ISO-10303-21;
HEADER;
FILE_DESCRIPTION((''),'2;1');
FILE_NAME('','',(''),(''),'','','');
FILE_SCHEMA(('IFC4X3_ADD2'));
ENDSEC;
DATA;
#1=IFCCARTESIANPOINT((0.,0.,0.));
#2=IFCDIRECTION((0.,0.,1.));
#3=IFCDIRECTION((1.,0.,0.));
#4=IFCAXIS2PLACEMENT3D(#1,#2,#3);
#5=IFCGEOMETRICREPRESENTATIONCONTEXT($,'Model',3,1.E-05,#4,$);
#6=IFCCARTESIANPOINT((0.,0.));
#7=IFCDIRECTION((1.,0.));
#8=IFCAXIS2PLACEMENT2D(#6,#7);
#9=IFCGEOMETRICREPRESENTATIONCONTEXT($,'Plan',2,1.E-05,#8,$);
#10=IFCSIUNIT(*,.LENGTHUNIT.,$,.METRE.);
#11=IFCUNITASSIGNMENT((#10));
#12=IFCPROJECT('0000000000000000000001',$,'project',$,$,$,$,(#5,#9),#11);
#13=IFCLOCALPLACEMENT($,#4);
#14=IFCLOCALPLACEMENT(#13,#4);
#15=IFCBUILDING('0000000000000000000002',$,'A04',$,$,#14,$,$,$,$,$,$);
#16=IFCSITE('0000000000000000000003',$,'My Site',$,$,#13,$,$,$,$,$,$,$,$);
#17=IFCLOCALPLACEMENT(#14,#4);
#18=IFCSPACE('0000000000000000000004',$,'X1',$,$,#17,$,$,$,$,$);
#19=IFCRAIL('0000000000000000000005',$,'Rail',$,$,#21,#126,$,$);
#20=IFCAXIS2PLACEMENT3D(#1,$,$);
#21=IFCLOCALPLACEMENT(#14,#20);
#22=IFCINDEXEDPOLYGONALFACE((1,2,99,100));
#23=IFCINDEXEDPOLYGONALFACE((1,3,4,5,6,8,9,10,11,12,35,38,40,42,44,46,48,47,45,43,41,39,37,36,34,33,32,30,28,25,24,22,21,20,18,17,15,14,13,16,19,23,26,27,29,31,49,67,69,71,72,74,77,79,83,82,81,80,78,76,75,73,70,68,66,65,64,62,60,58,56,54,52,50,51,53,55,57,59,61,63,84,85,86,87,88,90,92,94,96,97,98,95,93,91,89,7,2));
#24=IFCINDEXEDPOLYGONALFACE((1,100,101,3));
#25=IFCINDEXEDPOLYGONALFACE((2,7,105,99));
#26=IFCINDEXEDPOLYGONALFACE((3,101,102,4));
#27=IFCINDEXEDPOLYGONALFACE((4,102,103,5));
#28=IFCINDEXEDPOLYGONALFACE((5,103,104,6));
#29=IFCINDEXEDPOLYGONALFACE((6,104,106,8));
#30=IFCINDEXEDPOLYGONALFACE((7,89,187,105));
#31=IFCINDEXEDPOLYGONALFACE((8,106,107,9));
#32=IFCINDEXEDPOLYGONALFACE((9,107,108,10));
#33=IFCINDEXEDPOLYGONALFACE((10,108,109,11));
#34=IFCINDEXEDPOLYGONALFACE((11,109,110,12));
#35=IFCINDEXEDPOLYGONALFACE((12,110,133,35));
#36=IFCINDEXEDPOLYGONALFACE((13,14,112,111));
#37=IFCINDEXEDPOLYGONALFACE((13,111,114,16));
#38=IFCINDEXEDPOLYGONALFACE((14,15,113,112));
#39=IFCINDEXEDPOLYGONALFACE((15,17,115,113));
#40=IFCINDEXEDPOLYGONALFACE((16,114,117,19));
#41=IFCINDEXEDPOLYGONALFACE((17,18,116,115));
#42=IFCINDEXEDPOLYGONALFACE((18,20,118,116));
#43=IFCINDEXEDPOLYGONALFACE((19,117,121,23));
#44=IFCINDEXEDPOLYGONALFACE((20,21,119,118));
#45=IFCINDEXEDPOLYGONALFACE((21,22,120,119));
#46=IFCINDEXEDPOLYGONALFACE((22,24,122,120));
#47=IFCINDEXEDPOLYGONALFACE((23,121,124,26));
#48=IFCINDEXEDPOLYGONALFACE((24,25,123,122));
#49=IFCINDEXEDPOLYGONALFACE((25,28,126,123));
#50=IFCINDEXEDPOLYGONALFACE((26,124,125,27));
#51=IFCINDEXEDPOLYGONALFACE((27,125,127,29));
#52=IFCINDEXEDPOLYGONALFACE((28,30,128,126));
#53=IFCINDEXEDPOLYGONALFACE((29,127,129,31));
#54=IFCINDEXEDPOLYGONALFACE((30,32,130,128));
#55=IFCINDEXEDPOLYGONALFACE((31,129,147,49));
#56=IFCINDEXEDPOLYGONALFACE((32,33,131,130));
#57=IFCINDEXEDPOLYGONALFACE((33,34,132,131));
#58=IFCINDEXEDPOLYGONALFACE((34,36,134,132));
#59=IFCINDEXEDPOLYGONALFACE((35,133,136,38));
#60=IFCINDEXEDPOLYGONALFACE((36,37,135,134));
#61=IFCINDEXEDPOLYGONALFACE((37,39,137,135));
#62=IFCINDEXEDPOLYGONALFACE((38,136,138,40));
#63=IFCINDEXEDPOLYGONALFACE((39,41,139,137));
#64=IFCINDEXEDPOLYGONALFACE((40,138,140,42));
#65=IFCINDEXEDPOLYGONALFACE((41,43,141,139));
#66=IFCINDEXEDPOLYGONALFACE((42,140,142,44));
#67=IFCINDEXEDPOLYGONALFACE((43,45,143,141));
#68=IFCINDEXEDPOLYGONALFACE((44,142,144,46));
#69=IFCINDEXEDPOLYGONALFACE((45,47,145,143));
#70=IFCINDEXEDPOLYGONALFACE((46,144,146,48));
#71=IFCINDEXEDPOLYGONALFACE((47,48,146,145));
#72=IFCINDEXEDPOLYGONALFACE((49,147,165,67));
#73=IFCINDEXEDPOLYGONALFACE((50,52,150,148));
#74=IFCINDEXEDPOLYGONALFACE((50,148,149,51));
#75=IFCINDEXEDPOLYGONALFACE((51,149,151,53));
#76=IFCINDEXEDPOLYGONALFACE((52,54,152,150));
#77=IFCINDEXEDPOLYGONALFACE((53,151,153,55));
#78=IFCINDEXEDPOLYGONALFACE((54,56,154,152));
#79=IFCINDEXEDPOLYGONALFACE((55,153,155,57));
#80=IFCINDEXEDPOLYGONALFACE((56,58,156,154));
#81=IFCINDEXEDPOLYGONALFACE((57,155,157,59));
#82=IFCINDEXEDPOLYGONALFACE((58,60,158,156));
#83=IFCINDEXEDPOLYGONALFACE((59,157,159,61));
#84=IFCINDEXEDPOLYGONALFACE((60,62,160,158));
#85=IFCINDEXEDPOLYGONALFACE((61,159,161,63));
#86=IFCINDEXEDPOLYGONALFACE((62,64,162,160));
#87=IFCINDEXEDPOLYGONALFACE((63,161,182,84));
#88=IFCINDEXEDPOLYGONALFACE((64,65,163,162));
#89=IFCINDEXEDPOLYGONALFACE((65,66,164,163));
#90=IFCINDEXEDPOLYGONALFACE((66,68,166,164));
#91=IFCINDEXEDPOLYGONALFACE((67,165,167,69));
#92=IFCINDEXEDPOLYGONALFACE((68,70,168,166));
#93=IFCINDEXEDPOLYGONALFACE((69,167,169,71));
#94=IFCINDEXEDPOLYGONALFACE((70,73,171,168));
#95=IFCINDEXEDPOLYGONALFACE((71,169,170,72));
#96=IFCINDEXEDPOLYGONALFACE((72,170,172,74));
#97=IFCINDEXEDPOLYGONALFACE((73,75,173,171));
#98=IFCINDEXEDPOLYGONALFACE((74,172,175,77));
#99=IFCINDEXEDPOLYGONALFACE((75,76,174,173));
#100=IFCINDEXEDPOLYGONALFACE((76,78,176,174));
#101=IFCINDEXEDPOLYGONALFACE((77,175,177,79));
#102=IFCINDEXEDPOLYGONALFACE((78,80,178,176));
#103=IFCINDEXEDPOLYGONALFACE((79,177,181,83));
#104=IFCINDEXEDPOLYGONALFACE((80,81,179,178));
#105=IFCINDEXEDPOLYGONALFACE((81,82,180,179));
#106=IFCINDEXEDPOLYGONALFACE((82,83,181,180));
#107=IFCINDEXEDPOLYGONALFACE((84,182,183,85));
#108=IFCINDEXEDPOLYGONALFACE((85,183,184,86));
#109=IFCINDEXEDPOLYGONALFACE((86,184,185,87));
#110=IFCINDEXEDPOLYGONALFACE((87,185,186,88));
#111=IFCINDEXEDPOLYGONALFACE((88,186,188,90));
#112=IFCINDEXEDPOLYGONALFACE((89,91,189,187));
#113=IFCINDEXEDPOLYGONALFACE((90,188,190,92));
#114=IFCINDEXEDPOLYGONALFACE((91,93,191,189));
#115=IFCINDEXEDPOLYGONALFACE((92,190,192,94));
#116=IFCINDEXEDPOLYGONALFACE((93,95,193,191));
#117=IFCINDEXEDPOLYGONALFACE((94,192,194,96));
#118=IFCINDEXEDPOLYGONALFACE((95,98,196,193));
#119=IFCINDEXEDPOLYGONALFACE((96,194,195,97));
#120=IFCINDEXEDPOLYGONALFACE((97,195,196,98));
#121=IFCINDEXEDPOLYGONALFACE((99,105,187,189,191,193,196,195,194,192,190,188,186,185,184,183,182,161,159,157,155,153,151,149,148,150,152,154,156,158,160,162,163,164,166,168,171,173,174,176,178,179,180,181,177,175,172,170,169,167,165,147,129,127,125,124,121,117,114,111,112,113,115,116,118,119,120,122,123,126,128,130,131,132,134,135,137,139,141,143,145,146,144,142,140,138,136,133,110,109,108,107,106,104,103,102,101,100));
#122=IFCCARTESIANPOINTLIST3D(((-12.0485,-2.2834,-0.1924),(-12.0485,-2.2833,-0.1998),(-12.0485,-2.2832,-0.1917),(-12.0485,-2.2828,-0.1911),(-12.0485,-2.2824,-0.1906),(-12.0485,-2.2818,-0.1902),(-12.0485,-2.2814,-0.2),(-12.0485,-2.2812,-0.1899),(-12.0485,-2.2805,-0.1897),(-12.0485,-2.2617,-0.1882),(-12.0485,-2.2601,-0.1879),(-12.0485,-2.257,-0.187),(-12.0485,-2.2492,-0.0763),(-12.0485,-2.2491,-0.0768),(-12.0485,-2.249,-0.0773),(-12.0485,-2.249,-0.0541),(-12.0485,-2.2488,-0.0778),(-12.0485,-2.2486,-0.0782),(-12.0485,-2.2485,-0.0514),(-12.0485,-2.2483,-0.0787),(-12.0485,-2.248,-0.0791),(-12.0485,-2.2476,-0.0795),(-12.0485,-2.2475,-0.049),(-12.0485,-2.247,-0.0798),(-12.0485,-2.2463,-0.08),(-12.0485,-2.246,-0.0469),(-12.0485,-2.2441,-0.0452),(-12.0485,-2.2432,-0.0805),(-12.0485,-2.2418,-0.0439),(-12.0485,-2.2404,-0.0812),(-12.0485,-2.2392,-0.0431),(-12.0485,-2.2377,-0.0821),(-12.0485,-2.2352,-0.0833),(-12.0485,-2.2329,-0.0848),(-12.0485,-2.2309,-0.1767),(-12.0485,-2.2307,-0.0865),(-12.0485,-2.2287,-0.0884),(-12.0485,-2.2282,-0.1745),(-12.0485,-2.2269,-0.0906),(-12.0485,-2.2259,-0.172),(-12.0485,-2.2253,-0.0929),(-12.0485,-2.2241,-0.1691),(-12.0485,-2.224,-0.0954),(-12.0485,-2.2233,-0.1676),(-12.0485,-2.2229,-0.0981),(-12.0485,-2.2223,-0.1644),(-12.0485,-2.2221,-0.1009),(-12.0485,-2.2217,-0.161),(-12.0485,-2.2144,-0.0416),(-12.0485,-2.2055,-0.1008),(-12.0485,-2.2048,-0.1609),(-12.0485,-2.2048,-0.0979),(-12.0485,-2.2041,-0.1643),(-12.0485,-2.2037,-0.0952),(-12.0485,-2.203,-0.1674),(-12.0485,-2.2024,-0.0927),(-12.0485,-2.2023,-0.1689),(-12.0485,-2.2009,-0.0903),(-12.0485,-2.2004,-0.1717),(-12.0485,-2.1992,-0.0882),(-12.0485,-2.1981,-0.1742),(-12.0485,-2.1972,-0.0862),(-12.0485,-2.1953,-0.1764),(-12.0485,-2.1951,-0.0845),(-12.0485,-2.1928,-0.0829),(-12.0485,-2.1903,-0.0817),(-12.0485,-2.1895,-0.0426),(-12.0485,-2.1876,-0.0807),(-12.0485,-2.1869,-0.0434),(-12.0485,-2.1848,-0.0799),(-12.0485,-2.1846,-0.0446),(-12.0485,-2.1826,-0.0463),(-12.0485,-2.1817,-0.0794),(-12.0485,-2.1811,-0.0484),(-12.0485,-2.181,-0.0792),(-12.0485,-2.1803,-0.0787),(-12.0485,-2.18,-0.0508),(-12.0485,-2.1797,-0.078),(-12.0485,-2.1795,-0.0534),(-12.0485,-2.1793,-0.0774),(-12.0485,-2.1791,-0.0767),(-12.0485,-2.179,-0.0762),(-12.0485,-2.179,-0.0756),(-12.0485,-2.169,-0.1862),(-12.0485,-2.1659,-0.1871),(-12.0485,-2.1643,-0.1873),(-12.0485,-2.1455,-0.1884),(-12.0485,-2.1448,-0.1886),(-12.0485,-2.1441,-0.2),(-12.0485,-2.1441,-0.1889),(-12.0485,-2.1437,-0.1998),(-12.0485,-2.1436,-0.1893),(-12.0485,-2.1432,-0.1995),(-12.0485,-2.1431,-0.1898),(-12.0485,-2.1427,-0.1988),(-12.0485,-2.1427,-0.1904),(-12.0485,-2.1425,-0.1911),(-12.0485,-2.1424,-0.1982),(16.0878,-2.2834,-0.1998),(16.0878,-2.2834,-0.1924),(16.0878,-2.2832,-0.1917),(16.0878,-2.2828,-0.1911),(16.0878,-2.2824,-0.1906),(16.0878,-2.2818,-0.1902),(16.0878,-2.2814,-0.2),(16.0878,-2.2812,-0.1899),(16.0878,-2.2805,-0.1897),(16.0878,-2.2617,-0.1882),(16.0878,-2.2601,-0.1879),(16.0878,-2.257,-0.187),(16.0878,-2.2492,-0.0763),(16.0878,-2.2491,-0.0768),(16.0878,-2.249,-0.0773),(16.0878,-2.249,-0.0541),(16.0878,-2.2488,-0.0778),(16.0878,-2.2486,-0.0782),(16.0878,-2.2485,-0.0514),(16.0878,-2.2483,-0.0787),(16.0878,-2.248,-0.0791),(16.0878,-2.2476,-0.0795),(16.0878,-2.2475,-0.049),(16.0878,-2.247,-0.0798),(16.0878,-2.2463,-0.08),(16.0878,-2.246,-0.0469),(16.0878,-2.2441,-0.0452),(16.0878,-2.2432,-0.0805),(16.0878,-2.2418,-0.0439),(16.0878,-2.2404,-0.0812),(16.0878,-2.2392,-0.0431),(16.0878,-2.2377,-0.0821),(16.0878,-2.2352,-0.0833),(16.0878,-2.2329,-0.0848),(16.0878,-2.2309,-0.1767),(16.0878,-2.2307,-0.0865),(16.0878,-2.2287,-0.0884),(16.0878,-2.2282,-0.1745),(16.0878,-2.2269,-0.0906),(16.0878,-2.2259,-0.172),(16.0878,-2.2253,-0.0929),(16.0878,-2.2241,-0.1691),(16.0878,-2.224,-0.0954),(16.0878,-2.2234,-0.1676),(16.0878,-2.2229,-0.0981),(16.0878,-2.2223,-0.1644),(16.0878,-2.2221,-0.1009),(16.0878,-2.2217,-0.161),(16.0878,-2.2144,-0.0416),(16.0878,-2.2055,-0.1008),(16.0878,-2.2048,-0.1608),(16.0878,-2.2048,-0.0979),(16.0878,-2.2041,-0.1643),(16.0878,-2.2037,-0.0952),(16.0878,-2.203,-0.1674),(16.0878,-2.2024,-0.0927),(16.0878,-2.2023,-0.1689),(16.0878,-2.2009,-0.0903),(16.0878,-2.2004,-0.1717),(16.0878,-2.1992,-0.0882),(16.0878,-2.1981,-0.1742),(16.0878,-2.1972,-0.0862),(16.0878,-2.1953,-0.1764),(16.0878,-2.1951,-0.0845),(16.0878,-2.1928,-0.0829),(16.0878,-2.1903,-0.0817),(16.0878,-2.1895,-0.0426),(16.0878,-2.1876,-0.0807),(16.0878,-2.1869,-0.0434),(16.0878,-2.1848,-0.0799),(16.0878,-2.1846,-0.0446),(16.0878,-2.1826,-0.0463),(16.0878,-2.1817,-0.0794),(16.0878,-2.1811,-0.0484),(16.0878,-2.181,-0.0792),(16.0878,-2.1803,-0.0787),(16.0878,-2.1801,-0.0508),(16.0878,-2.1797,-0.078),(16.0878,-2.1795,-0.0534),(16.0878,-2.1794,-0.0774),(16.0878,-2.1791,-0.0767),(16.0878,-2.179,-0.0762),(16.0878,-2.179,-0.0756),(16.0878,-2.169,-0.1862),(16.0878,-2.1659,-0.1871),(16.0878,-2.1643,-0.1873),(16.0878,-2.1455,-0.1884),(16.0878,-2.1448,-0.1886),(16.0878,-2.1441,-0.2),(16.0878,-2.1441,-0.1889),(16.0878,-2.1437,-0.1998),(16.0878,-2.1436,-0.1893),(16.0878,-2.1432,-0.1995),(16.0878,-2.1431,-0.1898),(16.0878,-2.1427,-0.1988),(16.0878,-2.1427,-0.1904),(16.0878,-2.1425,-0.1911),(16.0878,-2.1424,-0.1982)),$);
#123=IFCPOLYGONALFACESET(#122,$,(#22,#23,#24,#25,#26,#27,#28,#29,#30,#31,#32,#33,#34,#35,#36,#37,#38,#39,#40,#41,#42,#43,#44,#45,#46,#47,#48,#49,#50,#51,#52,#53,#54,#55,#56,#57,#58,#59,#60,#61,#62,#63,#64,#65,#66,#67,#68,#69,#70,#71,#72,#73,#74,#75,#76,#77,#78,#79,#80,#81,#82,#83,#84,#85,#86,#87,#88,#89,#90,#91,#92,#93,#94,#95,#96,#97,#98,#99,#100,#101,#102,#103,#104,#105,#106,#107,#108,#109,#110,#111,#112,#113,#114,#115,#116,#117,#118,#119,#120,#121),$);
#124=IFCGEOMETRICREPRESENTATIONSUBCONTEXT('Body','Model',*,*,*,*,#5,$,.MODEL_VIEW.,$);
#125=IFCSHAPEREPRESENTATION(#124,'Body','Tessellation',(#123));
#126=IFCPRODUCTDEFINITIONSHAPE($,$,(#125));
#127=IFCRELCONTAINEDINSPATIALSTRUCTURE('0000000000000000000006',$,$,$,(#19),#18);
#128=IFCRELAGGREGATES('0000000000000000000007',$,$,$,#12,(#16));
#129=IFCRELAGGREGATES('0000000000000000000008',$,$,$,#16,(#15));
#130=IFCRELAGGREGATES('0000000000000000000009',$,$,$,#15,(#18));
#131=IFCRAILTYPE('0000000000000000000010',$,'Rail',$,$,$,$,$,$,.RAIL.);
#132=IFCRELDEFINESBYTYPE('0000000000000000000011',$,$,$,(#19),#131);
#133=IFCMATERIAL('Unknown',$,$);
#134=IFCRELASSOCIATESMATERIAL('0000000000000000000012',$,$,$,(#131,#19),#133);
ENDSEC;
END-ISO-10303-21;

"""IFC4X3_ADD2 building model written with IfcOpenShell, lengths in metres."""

from ifc_helpers import new_model, si_unit, frame, origin_with_axes, origin_2d_with_axis, place, context, subcontext, project, spatial, indexed_curve, outline, extrude, material, material_profile, profile_set, profile_usage, type_object, element, save


model = new_model("IFC4X3_ADD2")

# Units and contexts
model_context = context("Model", 3, precision=1e-05, world=origin_with_axes())
plan_context = context("Plan", 2, precision=1e-05, world=origin_2d_with_axis())
body_context = subcontext(model_context, "Body", "Model", "MODEL_VIEW")
ifc_project = project(units=[si_unit("LENGTHUNIT", "METRE")], contexts=[model_context, plan_context])

# Site, building, space
site_placement = place(None, origin_with_axes())
site = spatial("IfcSite", under=ifc_project, at=site_placement, Name="My Site")
building_placement = place(site_placement, origin_with_axes())
building = spatial("IfcBuilding", under=site, at=building_placement, Name="A04")
space_placement = place(building_placement, origin_with_axes())
space = spatial("IfcSpace", under=building, at=space_placement, Name="X1")

# Shared definitions
ifc_material_1 = material(Name="Unknown")

# Rail
ifc_material_profile_1 = material_profile(ifc_material_1, outline(indexed_curve([(-0.0706, 0.0076), (-0.0704, 0.0083), (-0.0701, 0.0089), (-0.0696, 0.0094), (-0.0691, 0.0098), (-0.0684, 0.0101), (-0.0677, 0.0103), (-0.0489, 0.0118), (-0.0474, 0.0121), (-0.0442, 0.013), (-0.0182, 0.0233), (-0.0154, 0.0255), (-0.0131, 0.028), (-0.0113, 0.0309), (-0.0106, 0.0324), (-0.0095, 0.0356), (-0.009, 0.039), (-0.0094, 0.0991), (-0.0102, 0.1019), (-0.0112, 0.1046), (-0.0126, 0.1071), (-0.0141, 0.1094), (-0.0159, 0.1116), (-0.0179, 0.1135), (-0.0201, 0.1152), (-0.0225, 0.1167), (-0.025, 0.1179), (-0.0276, 0.1188), (-0.0304, 0.1195), (-0.0335, 0.12), (-0.0342, 0.1202), (-0.0348, 0.1205), (-0.0353, 0.1209), (-0.0356, 0.1213), (-0.0358, 0.1218), (-0.0361, 0.1222), (-0.0362, 0.1227), (-0.0363, 0.1232), (-0.0364, 0.1237), (-0.0362, 0.1459), (-0.0358, 0.1486), (-0.0347, 0.151), (-0.0333, 0.1531), (-0.0313, 0.1548), (-0.0291, 0.1561), (-0.0265, 0.1569), (-0.0016, 0.1584), (0.0233, 0.1574), (0.0259, 0.1566), (0.0282, 0.1554), (0.0301, 0.1537), (0.0317, 0.1516), (0.0327, 0.1492), (0.0333, 0.1466), (0.0338, 0.1244), (0.0338, 0.1238), (0.0337, 0.1233), (0.0334, 0.1226), (0.0331, 0.122), (0.0325, 0.1213), (0.0317, 0.1208), (0.031, 0.1206), (0.0279, 0.1201), (0.0252, 0.1193), (0.0225, 0.1183), (0.02, 0.1171), (0.0177, 0.1155), (0.0155, 0.1138), (0.0136, 0.1118), (0.0118, 0.1097), (0.0103, 0.1073), (0.009, 0.1048), (0.008, 0.1021), (0.0073, 0.0992), (0.008, 0.0391), (0.0086, 0.0357), (0.0097, 0.0326), (0.0105, 0.0311), (0.0124, 0.0283), (0.0147, 0.0258), (0.0175, 0.0236), (0.0437, 0.0138), (0.0469, 0.0129), (0.0485, 0.0127), (0.0673, 0.0116), (0.068, 0.0114), (0.0686, 0.0111), (0.0692, 0.0107), (0.0697, 0.0102), (0.07, 0.0096), (0.0703, 0.0089), (0.0703, 0.0018), (0.0701, 0.0012), (0.0696, 0.0005), (0.0691, 0.0002), (0.0687, 0.0), (-0.0687, 0.0), (-0.0706, 0.0002), (-0.0706, 0.0076)])))
ifc_profile_set_1 = profile_set([ifc_material_profile_1])
ifc_profile_usage_1 = profile_usage(ifc_profile_set_1, cardinal=5)
rail_type = type_object("IfcRailType", Name="Rail", PredefinedType="RAIL", material=ifc_profile_set_1)
rail_1_placement = place(space_placement, frame((-12.0485, -2.2128, -0.2), z_axis=(1.0, 0.0, 0.0), x_axis=(0.0, 1.0, 0.0)))
element("IfcRail", 1, at=rail_1_placement, inside=space, type_object=rail_type, material=ifc_profile_usage_1, Name="Rail", context=body_context, shape_type="SweptSolid", body=[
    extrude(outline(indexed_curve([(-0.0706, 0.0076), (-0.0704, 0.0083), (-0.0701, 0.0089), (-0.0696, 0.0094), (-0.0691, 0.0098), (-0.0684, 0.0101), (-0.0677, 0.0103), (-0.0489, 0.0118), (-0.0474, 0.0121), (-0.0442, 0.013), (-0.0182, 0.0233), (-0.0154, 0.0255), (-0.0131, 0.028), (-0.0113, 0.0309), (-0.0106, 0.0324), (-0.0095, 0.0356), (-0.009, 0.039), (-0.0094, 0.0991), (-0.0102, 0.1019), (-0.0112, 0.1046), (-0.0126, 0.1071), (-0.0141, 0.1094), (-0.0159, 0.1116), (-0.0179, 0.1135), (-0.0201, 0.1152), (-0.0225, 0.1167), (-0.025, 0.1179), (-0.0276, 0.1188), (-0.0304, 0.1195), (-0.0335, 0.12), (-0.0342, 0.1202), (-0.0348, 0.1205), (-0.0353, 0.1209), (-0.0356, 0.1213), (-0.0358, 0.1218), (-0.0361, 0.1222), (-0.0362, 0.1227), (-0.0363, 0.1232), (-0.0364, 0.1237), (-0.0362, 0.1459), (-0.0358, 0.1486), (-0.0347, 0.151), (-0.0333, 0.1531), (-0.0313, 0.1548), (-0.0291, 0.1561), (-0.0265, 0.1569), (-0.0016, 0.1584), (0.0233, 0.1574), (0.0259, 0.1566), (0.0282, 0.1554), (0.0301, 0.1537), (0.0317, 0.1516), (0.0327, 0.1492), (0.0333, 0.1466), (0.0338, 0.1244), (0.0338, 0.1238), (0.0337, 0.1233), (0.0334, 0.1226), (0.0331, 0.122), (0.0325, 0.1213), (0.0317, 0.1208), (0.031, 0.1206), (0.0279, 0.1201), (0.0252, 0.1193), (0.0225, 0.1183), (0.02, 0.1171), (0.0177, 0.1155), (0.0155, 0.1138), (0.0136, 0.1118), (0.0118, 0.1097), (0.0103, 0.1073), (0.009, 0.1048), (0.008, 0.1021), (0.0073, 0.0992), (0.008, 0.0391), (0.0086, 0.0357), (0.0097, 0.0326), (0.0105, 0.0311), (0.0124, 0.0283), (0.0147, 0.0258), (0.0175, 0.0236), (0.0437, 0.0138), (0.0469, 0.0129), (0.0485, 0.0127), (0.0673, 0.0116), (0.068, 0.0114), (0.0686, 0.0111), (0.0692, 0.0107), (0.0697, 0.0102), (0.07, 0.0096), (0.0703, 0.0089), (0.0703, 0.0018), (0.0701, 0.0012), (0.0696, 0.0005), (0.0691, 0.0002), (0.0687, 0.0), (-0.0687, 0.0), (-0.0706, 0.0002), (-0.0706, 0.0076)])), origin_with_axes(), (0.0, 0.0, 1.0), 28.1363),
])

save(model, "model.ifc")
